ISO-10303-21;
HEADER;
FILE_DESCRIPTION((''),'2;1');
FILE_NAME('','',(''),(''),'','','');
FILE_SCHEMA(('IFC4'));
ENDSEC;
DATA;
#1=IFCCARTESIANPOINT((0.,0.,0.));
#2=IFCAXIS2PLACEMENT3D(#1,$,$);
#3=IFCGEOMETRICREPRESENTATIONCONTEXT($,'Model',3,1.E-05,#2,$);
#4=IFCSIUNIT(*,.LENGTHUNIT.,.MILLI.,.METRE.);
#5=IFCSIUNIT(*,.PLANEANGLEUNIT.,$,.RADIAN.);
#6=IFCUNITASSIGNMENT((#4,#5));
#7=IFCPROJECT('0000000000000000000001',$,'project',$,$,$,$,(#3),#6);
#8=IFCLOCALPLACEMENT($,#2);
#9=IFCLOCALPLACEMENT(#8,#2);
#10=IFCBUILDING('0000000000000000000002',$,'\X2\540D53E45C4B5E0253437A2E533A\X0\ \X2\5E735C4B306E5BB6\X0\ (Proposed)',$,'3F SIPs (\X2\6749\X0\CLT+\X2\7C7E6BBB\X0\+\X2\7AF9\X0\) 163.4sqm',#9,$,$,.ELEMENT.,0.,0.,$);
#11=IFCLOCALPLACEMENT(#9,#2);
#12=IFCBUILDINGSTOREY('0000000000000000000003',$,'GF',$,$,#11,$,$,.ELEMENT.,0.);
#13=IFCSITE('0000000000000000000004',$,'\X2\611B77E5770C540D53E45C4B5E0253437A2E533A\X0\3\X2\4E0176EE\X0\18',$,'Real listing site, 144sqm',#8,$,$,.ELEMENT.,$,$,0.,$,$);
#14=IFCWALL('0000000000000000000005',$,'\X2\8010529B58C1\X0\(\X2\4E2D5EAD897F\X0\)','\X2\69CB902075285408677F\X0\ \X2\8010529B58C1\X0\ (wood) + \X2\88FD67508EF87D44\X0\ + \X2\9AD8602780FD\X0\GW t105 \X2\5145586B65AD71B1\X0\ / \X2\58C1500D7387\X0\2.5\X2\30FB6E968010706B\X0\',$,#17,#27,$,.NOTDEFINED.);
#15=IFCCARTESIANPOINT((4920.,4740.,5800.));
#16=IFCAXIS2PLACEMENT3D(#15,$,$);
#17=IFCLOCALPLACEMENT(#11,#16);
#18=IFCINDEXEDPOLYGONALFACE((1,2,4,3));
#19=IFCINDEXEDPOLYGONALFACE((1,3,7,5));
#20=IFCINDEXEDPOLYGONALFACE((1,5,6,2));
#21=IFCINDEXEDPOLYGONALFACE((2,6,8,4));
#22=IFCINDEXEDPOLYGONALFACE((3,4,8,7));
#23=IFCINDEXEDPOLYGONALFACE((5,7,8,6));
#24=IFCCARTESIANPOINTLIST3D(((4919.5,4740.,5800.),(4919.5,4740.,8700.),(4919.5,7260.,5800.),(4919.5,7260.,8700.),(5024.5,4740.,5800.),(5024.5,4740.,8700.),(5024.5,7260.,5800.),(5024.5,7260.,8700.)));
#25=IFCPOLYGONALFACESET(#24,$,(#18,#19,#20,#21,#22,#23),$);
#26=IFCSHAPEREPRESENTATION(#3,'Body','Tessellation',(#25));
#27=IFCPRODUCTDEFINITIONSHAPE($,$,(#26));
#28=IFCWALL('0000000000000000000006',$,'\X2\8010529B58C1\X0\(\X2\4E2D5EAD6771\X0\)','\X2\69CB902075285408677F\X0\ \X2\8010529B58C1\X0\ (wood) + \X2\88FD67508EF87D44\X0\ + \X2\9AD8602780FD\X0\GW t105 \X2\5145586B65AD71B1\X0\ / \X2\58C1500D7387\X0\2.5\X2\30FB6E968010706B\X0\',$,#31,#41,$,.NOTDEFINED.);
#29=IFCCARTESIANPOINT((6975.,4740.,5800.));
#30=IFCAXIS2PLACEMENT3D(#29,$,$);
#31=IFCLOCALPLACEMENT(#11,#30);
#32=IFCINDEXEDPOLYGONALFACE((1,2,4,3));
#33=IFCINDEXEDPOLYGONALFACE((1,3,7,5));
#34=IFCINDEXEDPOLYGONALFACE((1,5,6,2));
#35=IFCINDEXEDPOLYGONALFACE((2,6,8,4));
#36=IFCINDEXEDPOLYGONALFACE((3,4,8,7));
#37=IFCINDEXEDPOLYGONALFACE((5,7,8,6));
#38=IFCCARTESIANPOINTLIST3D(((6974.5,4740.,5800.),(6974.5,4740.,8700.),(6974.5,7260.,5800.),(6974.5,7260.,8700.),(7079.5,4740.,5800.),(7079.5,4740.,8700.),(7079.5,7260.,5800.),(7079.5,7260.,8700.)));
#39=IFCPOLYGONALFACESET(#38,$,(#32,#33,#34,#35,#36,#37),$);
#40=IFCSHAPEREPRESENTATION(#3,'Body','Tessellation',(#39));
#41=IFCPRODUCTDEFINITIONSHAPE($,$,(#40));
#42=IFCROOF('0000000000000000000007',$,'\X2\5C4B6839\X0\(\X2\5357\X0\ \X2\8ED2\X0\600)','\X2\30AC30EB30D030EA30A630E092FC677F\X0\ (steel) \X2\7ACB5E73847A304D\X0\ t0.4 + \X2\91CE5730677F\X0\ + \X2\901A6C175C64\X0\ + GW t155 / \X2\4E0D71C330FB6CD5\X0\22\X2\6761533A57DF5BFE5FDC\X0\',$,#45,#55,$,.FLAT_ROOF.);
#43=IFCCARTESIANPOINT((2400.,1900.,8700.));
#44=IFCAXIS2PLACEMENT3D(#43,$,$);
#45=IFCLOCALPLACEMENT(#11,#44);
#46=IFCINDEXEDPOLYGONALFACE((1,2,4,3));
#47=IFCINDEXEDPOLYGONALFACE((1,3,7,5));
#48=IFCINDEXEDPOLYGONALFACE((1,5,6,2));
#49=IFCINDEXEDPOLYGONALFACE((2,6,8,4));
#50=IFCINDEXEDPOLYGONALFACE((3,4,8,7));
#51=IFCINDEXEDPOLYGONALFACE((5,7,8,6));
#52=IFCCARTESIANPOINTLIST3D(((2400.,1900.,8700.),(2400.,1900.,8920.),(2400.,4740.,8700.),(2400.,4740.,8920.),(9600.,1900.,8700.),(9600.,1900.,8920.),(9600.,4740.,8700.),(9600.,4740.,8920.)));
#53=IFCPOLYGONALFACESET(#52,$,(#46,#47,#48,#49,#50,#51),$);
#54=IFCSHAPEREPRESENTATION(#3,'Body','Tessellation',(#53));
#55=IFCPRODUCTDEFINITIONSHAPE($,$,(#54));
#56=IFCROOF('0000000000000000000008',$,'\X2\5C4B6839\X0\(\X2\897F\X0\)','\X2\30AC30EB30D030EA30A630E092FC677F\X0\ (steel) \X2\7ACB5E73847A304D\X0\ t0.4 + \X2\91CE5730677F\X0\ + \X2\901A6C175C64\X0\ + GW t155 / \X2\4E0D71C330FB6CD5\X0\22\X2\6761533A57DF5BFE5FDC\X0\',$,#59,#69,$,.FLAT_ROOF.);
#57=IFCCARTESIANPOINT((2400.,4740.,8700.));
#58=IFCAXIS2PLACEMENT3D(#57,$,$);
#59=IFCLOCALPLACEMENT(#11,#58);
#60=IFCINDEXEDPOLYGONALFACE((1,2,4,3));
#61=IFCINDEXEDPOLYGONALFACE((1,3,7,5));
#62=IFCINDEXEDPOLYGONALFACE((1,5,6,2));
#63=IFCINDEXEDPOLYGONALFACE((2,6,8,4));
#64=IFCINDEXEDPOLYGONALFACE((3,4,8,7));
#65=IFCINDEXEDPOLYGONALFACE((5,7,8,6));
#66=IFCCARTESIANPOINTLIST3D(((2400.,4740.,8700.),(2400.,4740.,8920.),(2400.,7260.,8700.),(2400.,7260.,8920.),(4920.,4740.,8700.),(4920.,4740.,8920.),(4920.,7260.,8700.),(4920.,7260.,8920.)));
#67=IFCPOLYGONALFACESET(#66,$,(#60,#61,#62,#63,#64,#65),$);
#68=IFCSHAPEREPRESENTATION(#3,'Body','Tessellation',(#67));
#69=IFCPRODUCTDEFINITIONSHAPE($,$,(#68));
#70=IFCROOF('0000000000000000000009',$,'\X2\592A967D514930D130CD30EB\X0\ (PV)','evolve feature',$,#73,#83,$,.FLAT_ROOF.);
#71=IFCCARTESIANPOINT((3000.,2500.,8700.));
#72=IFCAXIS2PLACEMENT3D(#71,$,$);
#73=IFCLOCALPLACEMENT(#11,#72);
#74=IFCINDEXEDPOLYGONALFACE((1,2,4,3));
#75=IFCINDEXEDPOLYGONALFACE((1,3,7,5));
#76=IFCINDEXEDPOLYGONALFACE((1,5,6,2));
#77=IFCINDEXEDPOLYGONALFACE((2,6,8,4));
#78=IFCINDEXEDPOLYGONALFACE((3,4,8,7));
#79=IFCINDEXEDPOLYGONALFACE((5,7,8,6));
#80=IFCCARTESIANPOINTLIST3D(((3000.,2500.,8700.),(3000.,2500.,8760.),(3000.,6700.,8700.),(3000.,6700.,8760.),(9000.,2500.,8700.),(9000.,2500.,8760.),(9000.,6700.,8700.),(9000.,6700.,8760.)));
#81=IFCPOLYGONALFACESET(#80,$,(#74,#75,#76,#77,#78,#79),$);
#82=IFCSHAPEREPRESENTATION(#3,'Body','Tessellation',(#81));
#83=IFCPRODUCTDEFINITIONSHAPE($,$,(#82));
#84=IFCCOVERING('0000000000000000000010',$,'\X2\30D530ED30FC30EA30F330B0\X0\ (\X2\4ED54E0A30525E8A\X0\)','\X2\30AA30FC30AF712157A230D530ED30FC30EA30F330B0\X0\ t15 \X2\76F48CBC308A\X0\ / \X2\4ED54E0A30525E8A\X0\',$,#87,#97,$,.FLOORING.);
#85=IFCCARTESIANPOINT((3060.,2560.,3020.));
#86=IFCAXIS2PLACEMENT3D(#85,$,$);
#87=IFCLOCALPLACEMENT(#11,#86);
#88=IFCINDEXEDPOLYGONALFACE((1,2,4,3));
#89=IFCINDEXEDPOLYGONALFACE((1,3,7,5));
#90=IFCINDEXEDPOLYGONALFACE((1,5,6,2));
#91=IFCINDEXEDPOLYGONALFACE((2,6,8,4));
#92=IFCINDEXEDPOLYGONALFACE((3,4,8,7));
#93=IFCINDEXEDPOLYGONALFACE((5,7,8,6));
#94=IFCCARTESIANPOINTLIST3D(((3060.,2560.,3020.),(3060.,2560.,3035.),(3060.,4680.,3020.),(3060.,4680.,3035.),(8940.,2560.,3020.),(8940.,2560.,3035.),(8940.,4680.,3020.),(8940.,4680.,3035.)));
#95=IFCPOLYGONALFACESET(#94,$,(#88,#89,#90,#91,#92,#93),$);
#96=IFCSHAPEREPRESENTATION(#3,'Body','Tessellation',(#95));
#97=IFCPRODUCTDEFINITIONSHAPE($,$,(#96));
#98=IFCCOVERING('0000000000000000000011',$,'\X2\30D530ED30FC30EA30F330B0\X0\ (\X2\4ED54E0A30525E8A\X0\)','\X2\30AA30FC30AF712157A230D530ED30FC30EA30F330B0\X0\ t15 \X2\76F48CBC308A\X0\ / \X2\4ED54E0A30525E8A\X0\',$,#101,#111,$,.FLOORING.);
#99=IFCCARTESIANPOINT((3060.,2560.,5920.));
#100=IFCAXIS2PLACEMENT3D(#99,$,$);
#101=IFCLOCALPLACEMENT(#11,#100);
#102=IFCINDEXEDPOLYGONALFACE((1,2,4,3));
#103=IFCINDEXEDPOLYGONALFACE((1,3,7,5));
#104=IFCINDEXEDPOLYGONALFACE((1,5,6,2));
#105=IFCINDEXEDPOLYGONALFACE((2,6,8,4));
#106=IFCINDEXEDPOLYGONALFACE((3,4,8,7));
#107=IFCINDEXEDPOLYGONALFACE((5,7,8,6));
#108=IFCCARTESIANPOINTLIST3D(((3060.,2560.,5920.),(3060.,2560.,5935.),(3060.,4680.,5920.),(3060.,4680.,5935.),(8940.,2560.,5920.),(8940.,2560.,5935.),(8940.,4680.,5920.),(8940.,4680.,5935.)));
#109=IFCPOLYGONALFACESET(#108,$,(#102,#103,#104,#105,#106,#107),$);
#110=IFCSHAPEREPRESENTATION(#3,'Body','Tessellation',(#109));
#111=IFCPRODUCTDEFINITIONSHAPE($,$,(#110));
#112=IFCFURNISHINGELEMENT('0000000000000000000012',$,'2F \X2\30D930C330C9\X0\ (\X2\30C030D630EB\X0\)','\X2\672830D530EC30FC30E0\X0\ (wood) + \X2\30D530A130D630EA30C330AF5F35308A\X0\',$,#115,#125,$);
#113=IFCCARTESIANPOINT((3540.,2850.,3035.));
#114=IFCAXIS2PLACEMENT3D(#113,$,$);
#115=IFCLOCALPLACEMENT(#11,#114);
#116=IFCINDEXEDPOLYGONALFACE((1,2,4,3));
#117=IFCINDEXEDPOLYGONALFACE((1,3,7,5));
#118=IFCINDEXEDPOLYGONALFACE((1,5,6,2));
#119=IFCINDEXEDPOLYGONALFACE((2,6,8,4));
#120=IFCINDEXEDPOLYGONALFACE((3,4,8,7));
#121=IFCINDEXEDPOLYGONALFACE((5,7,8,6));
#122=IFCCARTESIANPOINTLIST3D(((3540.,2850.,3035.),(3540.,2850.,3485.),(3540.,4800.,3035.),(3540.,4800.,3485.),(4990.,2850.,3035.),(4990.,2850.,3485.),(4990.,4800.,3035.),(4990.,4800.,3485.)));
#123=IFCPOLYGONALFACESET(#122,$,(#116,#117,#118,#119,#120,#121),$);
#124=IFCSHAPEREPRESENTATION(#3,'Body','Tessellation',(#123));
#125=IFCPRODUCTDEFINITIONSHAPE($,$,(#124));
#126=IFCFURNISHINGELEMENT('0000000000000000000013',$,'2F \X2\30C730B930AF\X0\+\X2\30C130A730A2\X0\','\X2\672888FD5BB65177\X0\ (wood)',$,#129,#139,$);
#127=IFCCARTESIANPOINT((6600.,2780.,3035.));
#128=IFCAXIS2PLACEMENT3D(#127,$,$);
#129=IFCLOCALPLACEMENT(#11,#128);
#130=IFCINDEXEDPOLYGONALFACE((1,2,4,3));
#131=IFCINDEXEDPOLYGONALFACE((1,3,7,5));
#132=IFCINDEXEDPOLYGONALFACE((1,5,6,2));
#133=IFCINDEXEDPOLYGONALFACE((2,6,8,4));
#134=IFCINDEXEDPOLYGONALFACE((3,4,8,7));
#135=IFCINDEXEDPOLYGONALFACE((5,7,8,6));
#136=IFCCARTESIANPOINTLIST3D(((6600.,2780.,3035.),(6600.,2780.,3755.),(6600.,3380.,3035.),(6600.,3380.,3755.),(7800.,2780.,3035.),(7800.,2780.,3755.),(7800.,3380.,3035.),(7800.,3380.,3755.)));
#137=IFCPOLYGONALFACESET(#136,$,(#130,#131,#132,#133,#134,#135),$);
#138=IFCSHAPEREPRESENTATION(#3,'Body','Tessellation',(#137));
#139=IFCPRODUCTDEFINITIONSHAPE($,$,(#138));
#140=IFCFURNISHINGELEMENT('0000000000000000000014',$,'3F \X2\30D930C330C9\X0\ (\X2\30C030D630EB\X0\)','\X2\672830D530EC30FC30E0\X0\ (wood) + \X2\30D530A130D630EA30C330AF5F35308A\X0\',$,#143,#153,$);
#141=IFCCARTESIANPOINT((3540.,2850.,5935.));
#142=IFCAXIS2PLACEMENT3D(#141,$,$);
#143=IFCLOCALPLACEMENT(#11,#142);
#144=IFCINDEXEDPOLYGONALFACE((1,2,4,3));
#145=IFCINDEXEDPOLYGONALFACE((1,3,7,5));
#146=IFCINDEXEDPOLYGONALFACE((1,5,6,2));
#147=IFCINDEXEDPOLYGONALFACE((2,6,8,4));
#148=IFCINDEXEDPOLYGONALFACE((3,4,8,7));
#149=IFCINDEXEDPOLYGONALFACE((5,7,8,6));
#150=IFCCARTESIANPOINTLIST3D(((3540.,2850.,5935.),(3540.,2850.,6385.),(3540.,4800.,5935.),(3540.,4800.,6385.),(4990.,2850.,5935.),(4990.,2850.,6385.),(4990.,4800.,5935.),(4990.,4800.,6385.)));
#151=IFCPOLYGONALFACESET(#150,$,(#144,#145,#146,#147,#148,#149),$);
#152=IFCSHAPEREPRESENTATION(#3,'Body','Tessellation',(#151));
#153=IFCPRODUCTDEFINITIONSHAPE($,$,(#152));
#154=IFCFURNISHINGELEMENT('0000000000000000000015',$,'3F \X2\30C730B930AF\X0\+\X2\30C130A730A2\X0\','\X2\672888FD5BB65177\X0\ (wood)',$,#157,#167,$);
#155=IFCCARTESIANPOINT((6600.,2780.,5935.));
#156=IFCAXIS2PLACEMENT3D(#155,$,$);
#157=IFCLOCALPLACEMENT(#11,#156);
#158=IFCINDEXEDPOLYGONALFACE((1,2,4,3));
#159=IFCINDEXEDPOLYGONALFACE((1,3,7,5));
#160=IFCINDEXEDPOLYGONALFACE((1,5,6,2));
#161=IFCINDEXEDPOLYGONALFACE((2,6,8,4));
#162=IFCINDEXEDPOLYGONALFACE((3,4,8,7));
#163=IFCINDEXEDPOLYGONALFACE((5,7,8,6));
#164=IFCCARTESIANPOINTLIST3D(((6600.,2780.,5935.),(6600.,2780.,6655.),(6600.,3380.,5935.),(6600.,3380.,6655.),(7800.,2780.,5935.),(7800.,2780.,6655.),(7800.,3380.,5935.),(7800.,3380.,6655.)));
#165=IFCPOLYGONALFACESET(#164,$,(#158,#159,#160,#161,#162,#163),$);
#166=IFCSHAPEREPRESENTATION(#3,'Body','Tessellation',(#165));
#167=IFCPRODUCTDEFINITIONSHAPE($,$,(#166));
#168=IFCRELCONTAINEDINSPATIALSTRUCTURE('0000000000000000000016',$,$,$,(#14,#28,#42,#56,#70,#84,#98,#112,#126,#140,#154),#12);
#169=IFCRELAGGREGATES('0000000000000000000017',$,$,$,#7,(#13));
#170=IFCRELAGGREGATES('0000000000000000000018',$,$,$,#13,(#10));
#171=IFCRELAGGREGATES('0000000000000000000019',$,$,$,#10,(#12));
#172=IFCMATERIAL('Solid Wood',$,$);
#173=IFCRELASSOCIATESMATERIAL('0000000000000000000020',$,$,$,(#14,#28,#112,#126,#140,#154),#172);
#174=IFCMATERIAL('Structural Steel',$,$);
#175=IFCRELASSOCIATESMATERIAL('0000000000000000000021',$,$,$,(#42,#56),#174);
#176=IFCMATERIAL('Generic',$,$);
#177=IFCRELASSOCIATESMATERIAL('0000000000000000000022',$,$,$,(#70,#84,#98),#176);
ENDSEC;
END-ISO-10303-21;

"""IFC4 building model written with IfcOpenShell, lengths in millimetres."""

from ifc_helpers import new_model, si_unit, frame, frame_2d, origin, place, context, project, spatial, rectangle, extrude, material, element, save


model = new_model("IFC4")

# Units and contexts
model_context = context("Model", 3, precision=1e-05, world=origin())
ifc_project = project(units=[si_unit("LENGTHUNIT", "METRE", prefix="MILLI"), si_unit("PLANEANGLEUNIT", "RADIAN")], contexts=[model_context])

# Site, building, storey
site_placement = place(None, origin())
site = spatial("IfcSite", under=ifc_project, at=site_placement, Name="愛知県名古屋市千種区3丁目18", ObjectType="Real listing site, 144sqm", CompositionType="ELEMENT", RefElevation=0.0)
building_placement = place(site_placement, origin())
building = spatial("IfcBuilding", under=site, at=building_placement, Name="名古屋市千種区 平屋の家 (Proposed)", ObjectType="3F SIPs (杉CLT+籾殻+竹) 163.4sqm", CompositionType="ELEMENT", ElevationOfRefHeight=0.0, ElevationOfTerrain=0.0)
storey_placement = place(building_placement, origin())
storey = spatial("IfcBuildingStorey", under=building, at=storey_placement, Name="GF", CompositionType="ELEMENT", Elevation=0.0)

# Shared definitions
ifc_material_1 = material(Name="Solid Wood")

# Walls
wall_1_placement = place(storey_placement, frame((4920.0, 4740.0, 5800.0)))
element("IfcWall", 1, at=wall_1_placement, inside=storey, material=ifc_material_1, Name="耐力壁(中庭西)", Description="構造用合板 耐力壁 (wood) + 製材軸組 + 高性能GW t105 充填断熱 / 壁倍率2.5・準耐火", PredefinedType="NOTDEFINED", context=model_context, shape_type="SweptSolid", body=[
    extrude(rectangle(XDim=105.0, YDim=2520.0, at=frame_2d((52.0, 1260.0))), frame((4920.0, 4740.0, 5800.0)), (0.0, 0.0, 1.0), 2900.0),
])
wall_2_placement = place(storey_placement, frame((6975.0, 4740.0, 5800.0)))
element("IfcWall", 2, at=wall_2_placement, inside=storey, material=ifc_material_1, Name="耐力壁(中庭東)", Description="構造用合板 耐力壁 (wood) + 製材軸組 + 高性能GW t105 充填断熱 / 壁倍率2.5・準耐火", PredefinedType="NOTDEFINED", context=model_context, shape_type="SweptSolid", body=[
    extrude(rectangle(XDim=105.0, YDim=2520.0, at=frame_2d((52.0, 1260.0))), frame((6975.0, 4740.0, 5800.0)), (0.0, 0.0, 1.0), 2900.0),
])

# Roofs
ifc_material_2 = material(Name="Structural Steel")
roof_1_placement = place(storey_placement, frame((2400.0, 1900.0, 8700.0)))
element("IfcRoof", 3, at=roof_1_placement, inside=storey, material=ifc_material_2, Name="屋根(南 軒600)", Description="ガルバリウム鋼板 (steel) 立平葺き t0.4 + 野地板 + 通気層 + GW t155 / 不燃・法22条区域対応", PredefinedType="FLAT_ROOF", context=model_context, shape_type="SweptSolid", body=[
    extrude(rectangle(XDim=7200.0, YDim=2840.0, at=frame_2d((3600.0, 1420.0))), frame((2400.0, 1900.0, 8700.0)), (0.0, 0.0, 1.0), 220.0),
])
roof_2_placement = place(storey_placement, frame((2400.0, 4740.0, 8700.0)))
element("IfcRoof", 4, at=roof_2_placement, inside=storey, material=ifc_material_2, Name="屋根(西)", Description="ガルバリウム鋼板 (steel) 立平葺き t0.4 + 野地板 + 通気層 + GW t155 / 不燃・法22条区域対応", PredefinedType="FLAT_ROOF", context=model_context, shape_type="SweptSolid", body=[
    extrude(rectangle(XDim=2520.0, YDim=2520.0, at=frame_2d((1260.0, 1260.0))), frame((2400.0, 4740.0, 8700.0)), (0.0, 0.0, 1.0), 220.0),
])
ifc_material_3 = material(Name="Generic")
roof_3_placement = place(storey_placement, frame((3000.0, 2500.0, 8700.0)))
element("IfcRoof", 5, at=roof_3_placement, inside=storey, material=ifc_material_3, Name="太陽光パネル (PV)", Description="evolve feature", PredefinedType="FLAT_ROOF", context=model_context, shape_type="SweptSolid", body=[
    extrude(rectangle(XDim=6000.0, YDim=4200.0, at=frame_2d((3000.0, 2100.0))), frame((3000.0, 2500.0, 8700.0)), (0.0, 0.0, 1.0), 60.0),
])

# Coverings
covering_1_placement = place(storey_placement, frame((3060.0, 2560.0, 3020.0)))
element("IfcCovering", 6, at=covering_1_placement, inside=storey, material=ifc_material_3, Name="フローリング (仕上げ床)", Description="オーク無垢フローリング t15 直貼り / 仕上げ床", PredefinedType="FLOORING", context=model_context, shape_type="SweptSolid", body=[
    extrude(rectangle(XDim=5880.0, YDim=2120.0, at=frame_2d((2940.0, 1060.0))), frame((3060.0, 2560.0, 3020.0)), (0.0, 0.0, 1.0), 15.0),
])
covering_2_placement = place(storey_placement, frame((3060.0, 2560.0, 5920.0)))
element("IfcCovering", 7, at=covering_2_placement, inside=storey, material=ifc_material_3, Name="フローリング (仕上げ床)", Description="オーク無垢フローリング t15 直貼り / 仕上げ床", PredefinedType="FLOORING", context=model_context, shape_type="SweptSolid", body=[
    extrude(rectangle(XDim=5880.0, YDim=2120.0, at=frame_2d((2940.0, 1060.0))), frame((3060.0, 2560.0, 5920.0)), (0.0, 0.0, 1.0), 15.0),
])

# Furnishing elements
furnishing_1_placement = place(storey_placement, frame((3540.0, 2850.0, 3035.0)))
element("IfcFurnishingElement", 8, at=furnishing_1_placement, inside=storey, material=ifc_material_1, Name="2F ベッド (ダブル)", Description="木フレーム (wood) + ファブリック張り", context=model_context, shape_type="SweptSolid", body=[
    extrude(rectangle(XDim=1450.0, YDim=1950.0, at=frame_2d((725.0, 975.0))), frame((3540.0, 2850.0, 3035.0)), (0.0, 0.0, 1.0), 450.0),
])
furnishing_2_placement = place(storey_placement, frame((6600.0, 2780.0, 3035.0)))
element("IfcFurnishingElement", 9, at=furnishing_2_placement, inside=storey, material=ifc_material_1, Name="2F デスク+チェア", Description="木製家具 (wood)", context=model_context, shape_type="SweptSolid", body=[
    extrude(rectangle(XDim=1200.0, YDim=600.0, at=frame_2d((600.0, 300.0))), frame((6600.0, 2780.0, 3035.0)), (0.0, 0.0, 1.0), 720.0),
])
furnishing_3_placement = place(storey_placement, frame((3540.0, 2850.0, 5935.0)))
element("IfcFurnishingElement", 10, at=furnishing_3_placement, inside=storey, material=ifc_material_1, Name="3F ベッド (ダブル)", Description="木フレーム (wood) + ファブリック張り", context=model_context, shape_type="SweptSolid", body=[
    extrude(rectangle(XDim=1450.0, YDim=1950.0, at=frame_2d((725.0, 975.0))), frame((3540.0, 2850.0, 5935.0)), (0.0, 0.0, 1.0), 450.0),
])
furnishing_4_placement = place(storey_placement, frame((6600.0, 2780.0, 5935.0)))
element("IfcFurnishingElement", 11, at=furnishing_4_placement, inside=storey, material=ifc_material_1, Name="3F デスク+チェア", Description="木製家具 (wood)", context=model_context, shape_type="SweptSolid", body=[
    extrude(rectangle(XDim=1200.0, YDim=600.0, at=frame_2d((600.0, 300.0))), frame((6600.0, 2780.0, 5935.0)), (0.0, 0.0, 1.0), 720.0),
])

save(model, "model.ifc")
